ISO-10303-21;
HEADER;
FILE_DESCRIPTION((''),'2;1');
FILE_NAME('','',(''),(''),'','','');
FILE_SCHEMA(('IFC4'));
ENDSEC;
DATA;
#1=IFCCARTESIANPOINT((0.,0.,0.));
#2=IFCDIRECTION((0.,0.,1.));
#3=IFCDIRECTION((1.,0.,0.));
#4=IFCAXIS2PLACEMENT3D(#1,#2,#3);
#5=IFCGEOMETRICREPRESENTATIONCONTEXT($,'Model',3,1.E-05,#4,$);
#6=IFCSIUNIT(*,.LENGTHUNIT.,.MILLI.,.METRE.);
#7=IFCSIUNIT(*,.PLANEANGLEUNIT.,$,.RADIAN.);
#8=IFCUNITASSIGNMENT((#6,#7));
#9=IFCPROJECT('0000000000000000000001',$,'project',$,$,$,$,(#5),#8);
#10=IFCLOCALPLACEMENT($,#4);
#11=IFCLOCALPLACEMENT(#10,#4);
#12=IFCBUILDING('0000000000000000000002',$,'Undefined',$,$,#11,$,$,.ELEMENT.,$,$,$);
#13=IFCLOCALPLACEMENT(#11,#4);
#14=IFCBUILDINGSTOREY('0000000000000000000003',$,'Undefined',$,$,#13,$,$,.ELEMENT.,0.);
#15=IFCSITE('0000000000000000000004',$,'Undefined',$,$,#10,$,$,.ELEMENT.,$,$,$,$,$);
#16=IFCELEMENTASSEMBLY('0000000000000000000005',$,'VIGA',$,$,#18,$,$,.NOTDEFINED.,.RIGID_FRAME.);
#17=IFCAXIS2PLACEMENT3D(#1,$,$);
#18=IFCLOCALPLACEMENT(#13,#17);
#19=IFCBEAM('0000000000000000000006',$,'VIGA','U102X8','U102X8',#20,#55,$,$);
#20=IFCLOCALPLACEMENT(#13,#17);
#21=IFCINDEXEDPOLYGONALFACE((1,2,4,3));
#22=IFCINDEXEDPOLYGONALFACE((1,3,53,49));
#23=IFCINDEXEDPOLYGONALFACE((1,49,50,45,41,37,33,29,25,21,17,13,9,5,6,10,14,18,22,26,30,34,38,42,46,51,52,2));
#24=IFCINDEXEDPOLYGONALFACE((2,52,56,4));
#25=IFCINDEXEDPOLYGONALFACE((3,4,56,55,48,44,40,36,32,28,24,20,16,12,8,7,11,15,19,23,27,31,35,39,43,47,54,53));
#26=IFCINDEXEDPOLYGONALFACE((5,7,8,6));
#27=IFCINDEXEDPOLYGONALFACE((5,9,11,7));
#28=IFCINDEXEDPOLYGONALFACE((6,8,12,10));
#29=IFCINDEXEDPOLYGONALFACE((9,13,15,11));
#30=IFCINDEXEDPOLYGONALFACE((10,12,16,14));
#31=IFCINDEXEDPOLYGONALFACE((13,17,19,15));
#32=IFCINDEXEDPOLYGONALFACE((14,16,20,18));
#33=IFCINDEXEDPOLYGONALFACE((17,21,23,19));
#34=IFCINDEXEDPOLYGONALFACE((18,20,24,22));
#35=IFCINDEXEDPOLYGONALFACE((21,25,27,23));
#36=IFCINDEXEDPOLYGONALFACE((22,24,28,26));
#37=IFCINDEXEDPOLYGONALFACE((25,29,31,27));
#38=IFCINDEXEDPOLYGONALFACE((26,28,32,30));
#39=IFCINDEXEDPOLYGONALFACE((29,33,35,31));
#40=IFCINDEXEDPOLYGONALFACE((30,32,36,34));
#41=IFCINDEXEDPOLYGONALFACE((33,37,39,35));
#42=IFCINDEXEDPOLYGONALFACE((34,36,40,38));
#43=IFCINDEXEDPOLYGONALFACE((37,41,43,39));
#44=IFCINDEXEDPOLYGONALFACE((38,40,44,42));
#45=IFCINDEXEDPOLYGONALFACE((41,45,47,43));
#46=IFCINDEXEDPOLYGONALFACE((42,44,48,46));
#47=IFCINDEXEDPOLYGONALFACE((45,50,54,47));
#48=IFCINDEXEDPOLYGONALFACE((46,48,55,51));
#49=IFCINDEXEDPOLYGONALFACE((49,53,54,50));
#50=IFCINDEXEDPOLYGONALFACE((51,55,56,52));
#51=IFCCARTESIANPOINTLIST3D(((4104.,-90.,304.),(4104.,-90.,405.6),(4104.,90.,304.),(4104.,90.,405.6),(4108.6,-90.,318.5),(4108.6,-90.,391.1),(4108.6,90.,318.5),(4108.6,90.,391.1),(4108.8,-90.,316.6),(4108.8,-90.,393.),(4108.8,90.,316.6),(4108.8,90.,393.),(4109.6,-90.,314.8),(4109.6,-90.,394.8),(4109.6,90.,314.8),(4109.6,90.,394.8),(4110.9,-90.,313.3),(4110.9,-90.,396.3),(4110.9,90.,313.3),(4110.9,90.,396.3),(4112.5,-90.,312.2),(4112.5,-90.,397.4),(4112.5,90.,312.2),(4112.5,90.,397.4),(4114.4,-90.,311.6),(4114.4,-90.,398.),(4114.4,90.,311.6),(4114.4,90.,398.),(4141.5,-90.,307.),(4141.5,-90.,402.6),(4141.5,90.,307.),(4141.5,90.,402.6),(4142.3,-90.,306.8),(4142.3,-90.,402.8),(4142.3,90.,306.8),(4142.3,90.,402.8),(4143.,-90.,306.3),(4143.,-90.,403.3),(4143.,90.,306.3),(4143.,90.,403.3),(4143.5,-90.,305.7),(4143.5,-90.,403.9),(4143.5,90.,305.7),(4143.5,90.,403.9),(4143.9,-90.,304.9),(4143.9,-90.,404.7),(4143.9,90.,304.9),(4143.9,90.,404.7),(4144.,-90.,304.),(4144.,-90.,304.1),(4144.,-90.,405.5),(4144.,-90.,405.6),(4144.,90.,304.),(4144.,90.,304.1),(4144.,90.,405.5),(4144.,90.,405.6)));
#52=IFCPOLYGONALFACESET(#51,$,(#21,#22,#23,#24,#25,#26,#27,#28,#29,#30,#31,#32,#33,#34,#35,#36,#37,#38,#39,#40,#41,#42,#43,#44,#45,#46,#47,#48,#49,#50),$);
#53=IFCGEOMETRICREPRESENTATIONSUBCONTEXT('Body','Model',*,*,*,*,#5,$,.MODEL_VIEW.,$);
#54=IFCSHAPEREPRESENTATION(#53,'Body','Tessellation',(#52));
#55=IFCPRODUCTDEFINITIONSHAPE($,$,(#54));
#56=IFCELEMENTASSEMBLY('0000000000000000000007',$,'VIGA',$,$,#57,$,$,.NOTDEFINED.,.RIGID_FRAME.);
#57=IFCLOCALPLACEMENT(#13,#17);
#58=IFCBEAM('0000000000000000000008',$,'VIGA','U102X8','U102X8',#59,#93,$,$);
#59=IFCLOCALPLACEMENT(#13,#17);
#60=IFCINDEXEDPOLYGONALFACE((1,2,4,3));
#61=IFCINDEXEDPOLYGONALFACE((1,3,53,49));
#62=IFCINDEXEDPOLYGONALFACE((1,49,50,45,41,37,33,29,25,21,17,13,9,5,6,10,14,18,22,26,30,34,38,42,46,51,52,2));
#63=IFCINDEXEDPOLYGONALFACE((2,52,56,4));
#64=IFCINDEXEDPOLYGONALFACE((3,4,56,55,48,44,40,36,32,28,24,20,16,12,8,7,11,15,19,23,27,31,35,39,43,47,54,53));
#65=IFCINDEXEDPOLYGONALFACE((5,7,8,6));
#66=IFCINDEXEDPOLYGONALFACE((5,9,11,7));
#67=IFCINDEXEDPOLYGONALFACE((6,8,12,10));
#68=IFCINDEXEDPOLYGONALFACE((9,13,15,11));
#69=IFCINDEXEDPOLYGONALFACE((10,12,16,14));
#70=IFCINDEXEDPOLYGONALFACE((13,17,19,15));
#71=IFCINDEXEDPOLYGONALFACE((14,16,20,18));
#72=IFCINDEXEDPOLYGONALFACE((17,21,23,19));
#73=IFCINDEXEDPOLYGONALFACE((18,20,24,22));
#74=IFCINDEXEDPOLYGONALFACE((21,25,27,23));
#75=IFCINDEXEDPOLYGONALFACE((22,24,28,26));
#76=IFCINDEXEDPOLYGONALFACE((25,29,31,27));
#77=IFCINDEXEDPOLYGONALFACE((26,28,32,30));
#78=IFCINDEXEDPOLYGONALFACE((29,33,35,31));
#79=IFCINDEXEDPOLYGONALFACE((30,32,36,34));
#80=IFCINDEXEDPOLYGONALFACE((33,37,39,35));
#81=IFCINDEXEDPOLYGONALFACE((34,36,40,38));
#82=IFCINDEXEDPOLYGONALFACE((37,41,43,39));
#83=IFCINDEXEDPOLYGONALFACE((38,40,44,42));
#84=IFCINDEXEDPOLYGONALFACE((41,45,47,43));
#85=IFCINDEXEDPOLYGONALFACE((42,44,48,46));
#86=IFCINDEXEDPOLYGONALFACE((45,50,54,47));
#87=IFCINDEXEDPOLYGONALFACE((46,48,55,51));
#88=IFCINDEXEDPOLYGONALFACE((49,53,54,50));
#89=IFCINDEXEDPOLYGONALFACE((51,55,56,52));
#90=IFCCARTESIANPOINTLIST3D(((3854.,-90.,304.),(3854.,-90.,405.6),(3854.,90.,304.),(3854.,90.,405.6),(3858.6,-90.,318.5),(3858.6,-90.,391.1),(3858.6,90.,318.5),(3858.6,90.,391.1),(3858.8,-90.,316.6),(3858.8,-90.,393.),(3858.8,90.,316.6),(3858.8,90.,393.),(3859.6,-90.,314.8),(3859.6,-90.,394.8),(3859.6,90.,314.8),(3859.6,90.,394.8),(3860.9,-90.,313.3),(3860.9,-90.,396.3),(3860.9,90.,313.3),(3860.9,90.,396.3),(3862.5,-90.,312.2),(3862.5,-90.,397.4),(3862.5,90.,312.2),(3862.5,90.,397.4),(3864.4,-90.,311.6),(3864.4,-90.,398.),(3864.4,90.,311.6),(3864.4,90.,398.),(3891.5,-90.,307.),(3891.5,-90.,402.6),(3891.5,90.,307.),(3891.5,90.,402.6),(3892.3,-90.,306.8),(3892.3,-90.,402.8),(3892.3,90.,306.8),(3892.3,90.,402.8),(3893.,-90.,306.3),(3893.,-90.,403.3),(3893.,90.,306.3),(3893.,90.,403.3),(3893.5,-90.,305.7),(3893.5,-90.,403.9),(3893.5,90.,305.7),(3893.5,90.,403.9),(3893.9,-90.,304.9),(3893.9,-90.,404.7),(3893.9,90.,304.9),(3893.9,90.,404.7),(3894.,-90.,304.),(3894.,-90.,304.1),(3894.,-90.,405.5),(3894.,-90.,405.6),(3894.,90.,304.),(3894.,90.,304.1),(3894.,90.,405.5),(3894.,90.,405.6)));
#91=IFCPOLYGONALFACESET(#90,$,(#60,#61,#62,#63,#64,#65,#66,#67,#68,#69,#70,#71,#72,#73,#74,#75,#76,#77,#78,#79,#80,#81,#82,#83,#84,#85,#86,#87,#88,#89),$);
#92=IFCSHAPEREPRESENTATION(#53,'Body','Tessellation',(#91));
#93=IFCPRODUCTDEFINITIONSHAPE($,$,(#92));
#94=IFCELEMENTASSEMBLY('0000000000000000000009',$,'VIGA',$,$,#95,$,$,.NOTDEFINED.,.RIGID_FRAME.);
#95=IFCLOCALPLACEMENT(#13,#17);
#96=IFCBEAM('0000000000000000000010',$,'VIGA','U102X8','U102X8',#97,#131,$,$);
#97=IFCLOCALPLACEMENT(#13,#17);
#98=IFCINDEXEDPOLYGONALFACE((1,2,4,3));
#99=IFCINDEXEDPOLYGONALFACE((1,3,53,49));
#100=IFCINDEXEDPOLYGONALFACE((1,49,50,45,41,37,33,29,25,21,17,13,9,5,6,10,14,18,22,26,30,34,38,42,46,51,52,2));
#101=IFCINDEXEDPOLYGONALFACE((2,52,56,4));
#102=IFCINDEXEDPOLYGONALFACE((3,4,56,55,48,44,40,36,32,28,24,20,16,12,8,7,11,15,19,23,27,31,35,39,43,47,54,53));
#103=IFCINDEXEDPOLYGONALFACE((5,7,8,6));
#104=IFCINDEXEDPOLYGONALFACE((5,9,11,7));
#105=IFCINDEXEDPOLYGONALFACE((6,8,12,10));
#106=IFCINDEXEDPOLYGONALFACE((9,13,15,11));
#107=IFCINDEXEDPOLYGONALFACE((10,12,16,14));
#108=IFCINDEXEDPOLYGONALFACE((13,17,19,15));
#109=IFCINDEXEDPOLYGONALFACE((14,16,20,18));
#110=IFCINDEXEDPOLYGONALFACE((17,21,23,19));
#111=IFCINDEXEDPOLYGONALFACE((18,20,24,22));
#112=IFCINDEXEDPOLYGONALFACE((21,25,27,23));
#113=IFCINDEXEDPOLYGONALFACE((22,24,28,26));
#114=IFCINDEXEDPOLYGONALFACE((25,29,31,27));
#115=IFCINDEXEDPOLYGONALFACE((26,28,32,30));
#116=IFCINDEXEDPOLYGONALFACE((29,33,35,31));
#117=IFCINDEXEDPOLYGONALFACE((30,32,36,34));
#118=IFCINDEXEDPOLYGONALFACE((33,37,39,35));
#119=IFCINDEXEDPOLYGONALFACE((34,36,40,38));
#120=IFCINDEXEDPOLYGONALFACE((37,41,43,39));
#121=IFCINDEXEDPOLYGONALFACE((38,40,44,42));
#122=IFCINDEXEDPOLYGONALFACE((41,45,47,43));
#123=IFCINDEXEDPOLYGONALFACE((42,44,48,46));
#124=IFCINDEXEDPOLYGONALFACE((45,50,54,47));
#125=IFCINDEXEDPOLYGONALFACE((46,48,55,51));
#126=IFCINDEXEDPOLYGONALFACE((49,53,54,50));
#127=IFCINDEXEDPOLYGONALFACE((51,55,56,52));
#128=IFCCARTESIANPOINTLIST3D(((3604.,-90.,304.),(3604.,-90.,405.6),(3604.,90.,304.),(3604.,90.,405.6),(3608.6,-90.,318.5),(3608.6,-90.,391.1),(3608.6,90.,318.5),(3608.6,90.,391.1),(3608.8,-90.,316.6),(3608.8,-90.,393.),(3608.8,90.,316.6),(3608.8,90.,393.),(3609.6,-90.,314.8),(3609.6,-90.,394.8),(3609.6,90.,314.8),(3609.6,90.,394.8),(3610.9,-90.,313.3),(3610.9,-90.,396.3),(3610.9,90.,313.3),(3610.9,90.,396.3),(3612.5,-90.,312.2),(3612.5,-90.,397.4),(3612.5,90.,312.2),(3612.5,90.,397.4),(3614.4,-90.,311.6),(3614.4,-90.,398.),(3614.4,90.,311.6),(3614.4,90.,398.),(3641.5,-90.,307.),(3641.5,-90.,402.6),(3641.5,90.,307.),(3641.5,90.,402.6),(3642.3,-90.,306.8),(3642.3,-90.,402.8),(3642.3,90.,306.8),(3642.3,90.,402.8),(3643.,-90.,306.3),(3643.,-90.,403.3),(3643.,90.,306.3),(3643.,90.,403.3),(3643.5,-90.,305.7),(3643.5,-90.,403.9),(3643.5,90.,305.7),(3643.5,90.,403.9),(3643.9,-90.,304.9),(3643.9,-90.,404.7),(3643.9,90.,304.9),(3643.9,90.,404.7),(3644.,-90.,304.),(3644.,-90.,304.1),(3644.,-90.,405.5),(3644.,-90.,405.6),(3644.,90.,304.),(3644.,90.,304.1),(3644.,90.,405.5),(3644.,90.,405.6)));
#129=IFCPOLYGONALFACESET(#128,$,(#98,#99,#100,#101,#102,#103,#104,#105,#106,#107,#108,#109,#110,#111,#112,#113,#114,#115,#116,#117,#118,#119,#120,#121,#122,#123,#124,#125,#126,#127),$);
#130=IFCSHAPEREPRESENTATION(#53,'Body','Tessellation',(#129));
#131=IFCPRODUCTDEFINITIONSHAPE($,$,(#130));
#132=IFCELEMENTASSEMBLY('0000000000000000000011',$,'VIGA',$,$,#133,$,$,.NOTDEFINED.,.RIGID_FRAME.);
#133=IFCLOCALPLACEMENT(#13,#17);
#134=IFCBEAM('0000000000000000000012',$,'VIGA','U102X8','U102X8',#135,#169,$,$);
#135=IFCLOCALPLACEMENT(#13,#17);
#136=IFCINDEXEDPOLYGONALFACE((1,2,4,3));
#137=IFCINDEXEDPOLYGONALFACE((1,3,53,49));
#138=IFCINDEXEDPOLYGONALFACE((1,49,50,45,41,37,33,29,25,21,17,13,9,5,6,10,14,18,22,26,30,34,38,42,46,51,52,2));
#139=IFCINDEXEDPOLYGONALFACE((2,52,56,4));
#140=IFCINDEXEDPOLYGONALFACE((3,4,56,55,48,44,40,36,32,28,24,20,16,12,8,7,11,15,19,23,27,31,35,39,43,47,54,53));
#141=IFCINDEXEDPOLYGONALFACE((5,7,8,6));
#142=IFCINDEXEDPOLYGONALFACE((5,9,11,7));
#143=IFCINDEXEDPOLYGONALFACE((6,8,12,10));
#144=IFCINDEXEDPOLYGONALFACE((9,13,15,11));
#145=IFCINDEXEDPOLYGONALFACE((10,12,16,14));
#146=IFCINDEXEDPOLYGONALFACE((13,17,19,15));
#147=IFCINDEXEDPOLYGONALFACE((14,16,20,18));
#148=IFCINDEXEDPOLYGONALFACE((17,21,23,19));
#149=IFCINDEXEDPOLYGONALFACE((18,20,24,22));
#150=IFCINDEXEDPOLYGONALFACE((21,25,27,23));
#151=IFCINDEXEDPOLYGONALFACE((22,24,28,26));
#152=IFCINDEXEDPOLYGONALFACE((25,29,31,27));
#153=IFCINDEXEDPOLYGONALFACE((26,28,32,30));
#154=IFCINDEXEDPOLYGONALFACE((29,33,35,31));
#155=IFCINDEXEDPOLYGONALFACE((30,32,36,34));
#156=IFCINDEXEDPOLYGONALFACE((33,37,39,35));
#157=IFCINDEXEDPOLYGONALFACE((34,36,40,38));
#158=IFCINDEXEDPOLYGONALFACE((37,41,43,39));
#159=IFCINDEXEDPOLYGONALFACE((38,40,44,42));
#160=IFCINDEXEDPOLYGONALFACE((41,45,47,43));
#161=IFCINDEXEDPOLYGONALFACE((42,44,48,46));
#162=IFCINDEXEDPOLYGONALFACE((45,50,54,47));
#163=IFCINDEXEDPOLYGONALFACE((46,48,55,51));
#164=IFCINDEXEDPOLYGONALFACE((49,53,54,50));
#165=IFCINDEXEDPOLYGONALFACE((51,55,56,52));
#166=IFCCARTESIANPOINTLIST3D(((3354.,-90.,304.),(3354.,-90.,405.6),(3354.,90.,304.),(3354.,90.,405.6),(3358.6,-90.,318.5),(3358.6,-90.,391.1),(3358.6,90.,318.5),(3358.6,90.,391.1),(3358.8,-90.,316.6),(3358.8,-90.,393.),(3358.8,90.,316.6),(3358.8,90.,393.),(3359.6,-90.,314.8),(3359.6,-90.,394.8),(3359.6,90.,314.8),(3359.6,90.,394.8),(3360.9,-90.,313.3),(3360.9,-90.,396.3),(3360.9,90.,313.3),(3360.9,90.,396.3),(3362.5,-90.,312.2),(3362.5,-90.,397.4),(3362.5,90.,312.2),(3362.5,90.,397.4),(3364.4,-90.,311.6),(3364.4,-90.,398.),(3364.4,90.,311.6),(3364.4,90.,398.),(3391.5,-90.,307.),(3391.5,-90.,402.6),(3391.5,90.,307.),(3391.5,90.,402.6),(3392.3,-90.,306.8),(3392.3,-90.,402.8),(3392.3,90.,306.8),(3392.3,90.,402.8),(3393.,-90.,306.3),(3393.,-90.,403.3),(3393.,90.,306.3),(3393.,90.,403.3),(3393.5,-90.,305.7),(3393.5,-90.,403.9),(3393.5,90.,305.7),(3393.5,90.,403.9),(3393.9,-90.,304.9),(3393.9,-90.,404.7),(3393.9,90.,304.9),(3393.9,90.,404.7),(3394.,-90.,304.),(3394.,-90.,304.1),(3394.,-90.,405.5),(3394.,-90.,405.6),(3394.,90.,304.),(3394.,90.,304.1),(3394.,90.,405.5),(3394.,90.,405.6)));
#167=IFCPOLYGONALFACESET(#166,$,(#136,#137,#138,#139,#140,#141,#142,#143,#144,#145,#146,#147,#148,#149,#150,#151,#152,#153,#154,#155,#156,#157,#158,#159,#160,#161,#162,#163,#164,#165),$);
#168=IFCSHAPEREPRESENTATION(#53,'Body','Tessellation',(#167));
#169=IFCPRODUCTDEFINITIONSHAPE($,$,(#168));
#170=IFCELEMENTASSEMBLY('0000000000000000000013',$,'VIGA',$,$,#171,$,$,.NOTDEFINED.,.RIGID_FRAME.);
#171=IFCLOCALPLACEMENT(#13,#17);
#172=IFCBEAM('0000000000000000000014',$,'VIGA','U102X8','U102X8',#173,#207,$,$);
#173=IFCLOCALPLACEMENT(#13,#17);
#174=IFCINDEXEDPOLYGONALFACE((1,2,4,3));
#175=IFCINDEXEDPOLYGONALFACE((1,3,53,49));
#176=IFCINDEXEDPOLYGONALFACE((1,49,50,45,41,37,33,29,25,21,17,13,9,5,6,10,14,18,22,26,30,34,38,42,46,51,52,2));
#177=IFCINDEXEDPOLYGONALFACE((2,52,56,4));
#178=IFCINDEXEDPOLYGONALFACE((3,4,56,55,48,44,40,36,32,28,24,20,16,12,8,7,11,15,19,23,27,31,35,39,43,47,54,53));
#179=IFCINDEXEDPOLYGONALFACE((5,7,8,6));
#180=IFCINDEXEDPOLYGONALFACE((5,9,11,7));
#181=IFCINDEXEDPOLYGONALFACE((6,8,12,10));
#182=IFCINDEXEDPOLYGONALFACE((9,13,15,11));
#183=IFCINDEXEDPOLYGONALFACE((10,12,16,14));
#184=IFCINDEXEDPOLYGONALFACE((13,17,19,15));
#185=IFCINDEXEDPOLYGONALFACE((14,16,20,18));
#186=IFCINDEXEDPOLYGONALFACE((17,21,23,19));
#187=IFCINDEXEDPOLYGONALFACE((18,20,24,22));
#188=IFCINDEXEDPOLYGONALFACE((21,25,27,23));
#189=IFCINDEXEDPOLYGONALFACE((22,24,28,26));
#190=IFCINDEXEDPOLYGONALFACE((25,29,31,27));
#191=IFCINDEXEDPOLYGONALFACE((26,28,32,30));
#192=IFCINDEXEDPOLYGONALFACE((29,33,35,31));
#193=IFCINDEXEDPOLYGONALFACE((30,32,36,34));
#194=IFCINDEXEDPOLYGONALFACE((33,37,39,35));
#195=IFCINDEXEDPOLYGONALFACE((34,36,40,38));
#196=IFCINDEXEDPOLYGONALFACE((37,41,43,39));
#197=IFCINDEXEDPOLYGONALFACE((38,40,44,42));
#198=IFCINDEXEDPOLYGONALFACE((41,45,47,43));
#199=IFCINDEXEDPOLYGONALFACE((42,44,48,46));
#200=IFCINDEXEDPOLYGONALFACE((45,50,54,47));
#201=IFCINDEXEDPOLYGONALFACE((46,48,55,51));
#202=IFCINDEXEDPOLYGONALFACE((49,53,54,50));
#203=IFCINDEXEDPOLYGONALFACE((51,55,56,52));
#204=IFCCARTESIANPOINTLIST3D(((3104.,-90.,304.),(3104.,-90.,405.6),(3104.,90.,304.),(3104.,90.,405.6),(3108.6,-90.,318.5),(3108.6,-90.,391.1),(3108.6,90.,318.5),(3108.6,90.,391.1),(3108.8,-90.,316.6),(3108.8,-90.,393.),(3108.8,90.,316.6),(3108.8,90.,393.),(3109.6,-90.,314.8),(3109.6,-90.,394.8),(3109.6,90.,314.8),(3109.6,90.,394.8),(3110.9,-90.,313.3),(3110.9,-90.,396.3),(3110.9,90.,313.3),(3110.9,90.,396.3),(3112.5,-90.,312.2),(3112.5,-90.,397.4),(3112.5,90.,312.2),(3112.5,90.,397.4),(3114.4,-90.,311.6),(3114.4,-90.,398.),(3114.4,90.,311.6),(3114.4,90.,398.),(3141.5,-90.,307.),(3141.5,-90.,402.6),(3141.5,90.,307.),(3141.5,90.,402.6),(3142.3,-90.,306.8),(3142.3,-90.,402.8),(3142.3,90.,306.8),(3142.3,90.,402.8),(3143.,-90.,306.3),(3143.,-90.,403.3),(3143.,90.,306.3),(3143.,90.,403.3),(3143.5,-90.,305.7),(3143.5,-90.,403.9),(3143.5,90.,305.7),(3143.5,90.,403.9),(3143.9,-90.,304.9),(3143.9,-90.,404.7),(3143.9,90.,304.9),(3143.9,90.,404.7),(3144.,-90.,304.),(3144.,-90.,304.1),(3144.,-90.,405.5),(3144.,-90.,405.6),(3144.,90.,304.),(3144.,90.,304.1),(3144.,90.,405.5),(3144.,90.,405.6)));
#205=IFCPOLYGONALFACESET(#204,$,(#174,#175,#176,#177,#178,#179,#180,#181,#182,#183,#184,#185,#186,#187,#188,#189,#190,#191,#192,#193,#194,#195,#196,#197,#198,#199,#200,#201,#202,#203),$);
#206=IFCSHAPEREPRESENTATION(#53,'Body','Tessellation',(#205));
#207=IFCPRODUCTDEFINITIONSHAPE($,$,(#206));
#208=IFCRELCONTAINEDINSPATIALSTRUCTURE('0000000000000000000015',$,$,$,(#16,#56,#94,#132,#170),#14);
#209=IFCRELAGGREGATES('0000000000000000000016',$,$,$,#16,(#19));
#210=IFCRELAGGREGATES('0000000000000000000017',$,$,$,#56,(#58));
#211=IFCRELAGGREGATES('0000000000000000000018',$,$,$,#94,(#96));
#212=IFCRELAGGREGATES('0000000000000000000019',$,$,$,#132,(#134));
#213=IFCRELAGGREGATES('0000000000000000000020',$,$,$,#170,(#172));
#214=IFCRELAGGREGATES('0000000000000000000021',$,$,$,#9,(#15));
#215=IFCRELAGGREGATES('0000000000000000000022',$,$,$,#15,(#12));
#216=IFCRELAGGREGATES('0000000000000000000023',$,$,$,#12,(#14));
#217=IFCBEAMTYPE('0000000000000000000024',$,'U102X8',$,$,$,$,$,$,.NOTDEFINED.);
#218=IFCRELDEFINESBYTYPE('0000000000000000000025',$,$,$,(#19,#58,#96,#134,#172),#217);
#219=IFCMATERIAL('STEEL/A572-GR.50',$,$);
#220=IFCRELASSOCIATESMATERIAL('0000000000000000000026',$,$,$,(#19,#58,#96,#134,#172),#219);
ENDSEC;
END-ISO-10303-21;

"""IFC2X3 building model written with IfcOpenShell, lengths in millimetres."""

from ifc_helpers import new_model, si_unit, frame, origin_with_axes, origin_2d_with_axis, place, context, subcontext, project, spatial, u_section, extrude, material, type_object, element, aggregate, save


model = new_model("IFC2X3")

# Units and contexts
model_context = context("Model", 3, precision=1e-05, world=origin_with_axes())
body_context = subcontext(model_context, "Body", "Model", "MODEL_VIEW")
ifc_project = project(units=[si_unit("LENGTHUNIT", "METRE", prefix="MILLI"), si_unit("PLANEANGLEUNIT", "RADIAN")], contexts=[model_context])

# Site, building, storey
site_placement = place(None, origin_with_axes())
site = spatial("IfcSite", under=ifc_project, at=site_placement, Name="Undefined", CompositionType="ELEMENT")
building_placement = place(site_placement, origin_with_axes())
building = spatial("IfcBuilding", under=site, at=building_placement, Name="Undefined", CompositionType="ELEMENT")
storey_placement = place(building_placement, origin_with_axes())
storey = spatial("IfcBuildingStorey", under=building, at=storey_placement, Name="Undefined", CompositionType="ELEMENT", Elevation=0.0)

# Element assemblies, beams
ifc_material_1 = material(Name="STEEL/A572-GR.50")
beam_type = type_object("IfcBeamType", Name="U102X8", PredefinedType="NOTDEFINED")
assembly_1_placement = place(storey_placement, origin_with_axes())
assembly_1 = element("IfcElementAssembly", 1, at=assembly_1_placement, inside=storey, Name="VIGA", AssemblyPlace="NOTDEFINED", PredefinedType="RIGID_FRAME")
beam_1_placement = place(assembly_1_placement, frame((4124.0, -90.0, 354.8), z_axis=(0.0, 0.0, 1.0), x_axis=(0.0, 1.0, 0.0)))
beam_1 = element("IfcBeam", 2, at=beam_1_placement, type_object=beam_type, material=ifc_material_1, Name="VIGA", Description="U102X8", ObjectType="U102X8", context=body_context, shape_type="SweptSolid", body=[
    extrude(u_section(Depth=101.6, FlangeWidth=40.0, WebThickness=4.6, FlangeThickness=6.0, FilletRadius=7.0, EdgeRadius=3.0, FlangeSlope=0.16839, at=origin_2d_with_axis()), frame((180.0, 0.0, 0.0), z_axis=(-1.0, 0.0, 0.0), x_axis=(0.0, -1.0, 0.0)), (0.0, 0.0, 1.0), 180.0),
])
aggregate(assembly_1, [beam_1])
assembly_2_placement = place(storey_placement, origin_with_axes())
assembly_2 = element("IfcElementAssembly", 3, at=assembly_2_placement, inside=storey, Name="VIGA", AssemblyPlace="NOTDEFINED", PredefinedType="RIGID_FRAME")
beam_2_placement = place(assembly_2_placement, frame((3874.0, -90.0, 354.8), z_axis=(0.0, 0.0, 1.0), x_axis=(0.0, 1.0, 0.0)))
beam_2 = element("IfcBeam", 4, at=beam_2_placement, type_object=beam_type, material=ifc_material_1, Name="VIGA", Description="U102X8", ObjectType="U102X8", context=body_context, shape_type="SweptSolid", body=[
    extrude(u_section(Depth=101.6, FlangeWidth=40.0, WebThickness=4.6, FlangeThickness=6.0, FilletRadius=7.0, EdgeRadius=3.0, FlangeSlope=0.16839, at=origin_2d_with_axis()), frame((180.0, 0.0, 0.0), z_axis=(-1.0, 0.0, 0.0), x_axis=(0.0, -1.0, 0.0)), (0.0, 0.0, 1.0), 180.0),
])
aggregate(assembly_2, [beam_2])
assembly_3_placement = place(storey_placement, origin_with_axes())
assembly_3 = element("IfcElementAssembly", 5, at=assembly_3_placement, inside=storey, Name="VIGA", AssemblyPlace="NOTDEFINED", PredefinedType="RIGID_FRAME")
beam_3_placement = place(assembly_3_placement, frame((3624.0, -90.0, 354.8), z_axis=(0.0, 0.0, 1.0), x_axis=(0.0, 1.0, 0.0)))
beam_3 = element("IfcBeam", 6, at=beam_3_placement, type_object=beam_type, material=ifc_material_1, Name="VIGA", Description="U102X8", ObjectType="U102X8", context=body_context, shape_type="SweptSolid", body=[
    extrude(u_section(Depth=101.6, FlangeWidth=40.0, WebThickness=4.6, FlangeThickness=6.0, FilletRadius=7.0, EdgeRadius=3.0, FlangeSlope=0.16839, at=origin_2d_with_axis()), frame((180.0, 0.0, 0.0), z_axis=(-1.0, 0.0, 0.0), x_axis=(0.0, -1.0, 0.0)), (0.0, 0.0, 1.0), 180.0),
])
aggregate(assembly_3, [beam_3])
assembly_4_placement = place(storey_placement, origin_with_axes())
assembly_4 = element("IfcElementAssembly", 7, at=assembly_4_placement, inside=storey, Name="VIGA", AssemblyPlace="NOTDEFINED", PredefinedType="RIGID_FRAME")
beam_4_placement = place(assembly_4_placement, frame((3374.0, -90.0, 354.8), z_axis=(0.0, 0.0, 1.0), x_axis=(0.0, 1.0, 0.0)))
beam_4 = element("IfcBeam", 8, at=beam_4_placement, type_object=beam_type, material=ifc_material_1, Name="VIGA", Description="U102X8", ObjectType="U102X8", context=body_context, shape_type="SweptSolid", body=[
    extrude(u_section(Depth=101.6, FlangeWidth=40.0, WebThickness=4.6, FlangeThickness=6.0, FilletRadius=7.0, EdgeRadius=3.0, FlangeSlope=0.16839, at=origin_2d_with_axis()), frame((180.0, 0.0, 0.0), z_axis=(-1.0, 0.0, 0.0), x_axis=(0.0, -1.0, 0.0)), (0.0, 0.0, 1.0), 180.0),
])
aggregate(assembly_4, [beam_4])
assembly_5_placement = place(storey_placement, origin_with_axes())
assembly_5 = element("IfcElementAssembly", 9, at=assembly_5_placement, inside=storey, Name="VIGA", AssemblyPlace="NOTDEFINED", PredefinedType="RIGID_FRAME")
beam_5_placement = place(assembly_5_placement, frame((3124.0, -90.0, 354.8), z_axis=(0.0, 0.0, 1.0), x_axis=(0.0, 1.0, 0.0)))
beam_5 = element("IfcBeam", 10, at=beam_5_placement, type_object=beam_type, material=ifc_material_1, Name="VIGA", Description="U102X8", ObjectType="U102X8", context=body_context, shape_type="SweptSolid", body=[
    extrude(u_section(Depth=101.6, FlangeWidth=40.0, WebThickness=4.6, FlangeThickness=6.0, FilletRadius=7.0, EdgeRadius=3.0, FlangeSlope=0.16839, at=origin_2d_with_axis()), frame((180.0, 0.0, 0.0), z_axis=(-1.0, 0.0, 0.0), x_axis=(0.0, -1.0, 0.0)), (0.0, 0.0, 1.0), 180.0),
])
aggregate(assembly_5, [beam_5])

save(model, "model.ifc")
